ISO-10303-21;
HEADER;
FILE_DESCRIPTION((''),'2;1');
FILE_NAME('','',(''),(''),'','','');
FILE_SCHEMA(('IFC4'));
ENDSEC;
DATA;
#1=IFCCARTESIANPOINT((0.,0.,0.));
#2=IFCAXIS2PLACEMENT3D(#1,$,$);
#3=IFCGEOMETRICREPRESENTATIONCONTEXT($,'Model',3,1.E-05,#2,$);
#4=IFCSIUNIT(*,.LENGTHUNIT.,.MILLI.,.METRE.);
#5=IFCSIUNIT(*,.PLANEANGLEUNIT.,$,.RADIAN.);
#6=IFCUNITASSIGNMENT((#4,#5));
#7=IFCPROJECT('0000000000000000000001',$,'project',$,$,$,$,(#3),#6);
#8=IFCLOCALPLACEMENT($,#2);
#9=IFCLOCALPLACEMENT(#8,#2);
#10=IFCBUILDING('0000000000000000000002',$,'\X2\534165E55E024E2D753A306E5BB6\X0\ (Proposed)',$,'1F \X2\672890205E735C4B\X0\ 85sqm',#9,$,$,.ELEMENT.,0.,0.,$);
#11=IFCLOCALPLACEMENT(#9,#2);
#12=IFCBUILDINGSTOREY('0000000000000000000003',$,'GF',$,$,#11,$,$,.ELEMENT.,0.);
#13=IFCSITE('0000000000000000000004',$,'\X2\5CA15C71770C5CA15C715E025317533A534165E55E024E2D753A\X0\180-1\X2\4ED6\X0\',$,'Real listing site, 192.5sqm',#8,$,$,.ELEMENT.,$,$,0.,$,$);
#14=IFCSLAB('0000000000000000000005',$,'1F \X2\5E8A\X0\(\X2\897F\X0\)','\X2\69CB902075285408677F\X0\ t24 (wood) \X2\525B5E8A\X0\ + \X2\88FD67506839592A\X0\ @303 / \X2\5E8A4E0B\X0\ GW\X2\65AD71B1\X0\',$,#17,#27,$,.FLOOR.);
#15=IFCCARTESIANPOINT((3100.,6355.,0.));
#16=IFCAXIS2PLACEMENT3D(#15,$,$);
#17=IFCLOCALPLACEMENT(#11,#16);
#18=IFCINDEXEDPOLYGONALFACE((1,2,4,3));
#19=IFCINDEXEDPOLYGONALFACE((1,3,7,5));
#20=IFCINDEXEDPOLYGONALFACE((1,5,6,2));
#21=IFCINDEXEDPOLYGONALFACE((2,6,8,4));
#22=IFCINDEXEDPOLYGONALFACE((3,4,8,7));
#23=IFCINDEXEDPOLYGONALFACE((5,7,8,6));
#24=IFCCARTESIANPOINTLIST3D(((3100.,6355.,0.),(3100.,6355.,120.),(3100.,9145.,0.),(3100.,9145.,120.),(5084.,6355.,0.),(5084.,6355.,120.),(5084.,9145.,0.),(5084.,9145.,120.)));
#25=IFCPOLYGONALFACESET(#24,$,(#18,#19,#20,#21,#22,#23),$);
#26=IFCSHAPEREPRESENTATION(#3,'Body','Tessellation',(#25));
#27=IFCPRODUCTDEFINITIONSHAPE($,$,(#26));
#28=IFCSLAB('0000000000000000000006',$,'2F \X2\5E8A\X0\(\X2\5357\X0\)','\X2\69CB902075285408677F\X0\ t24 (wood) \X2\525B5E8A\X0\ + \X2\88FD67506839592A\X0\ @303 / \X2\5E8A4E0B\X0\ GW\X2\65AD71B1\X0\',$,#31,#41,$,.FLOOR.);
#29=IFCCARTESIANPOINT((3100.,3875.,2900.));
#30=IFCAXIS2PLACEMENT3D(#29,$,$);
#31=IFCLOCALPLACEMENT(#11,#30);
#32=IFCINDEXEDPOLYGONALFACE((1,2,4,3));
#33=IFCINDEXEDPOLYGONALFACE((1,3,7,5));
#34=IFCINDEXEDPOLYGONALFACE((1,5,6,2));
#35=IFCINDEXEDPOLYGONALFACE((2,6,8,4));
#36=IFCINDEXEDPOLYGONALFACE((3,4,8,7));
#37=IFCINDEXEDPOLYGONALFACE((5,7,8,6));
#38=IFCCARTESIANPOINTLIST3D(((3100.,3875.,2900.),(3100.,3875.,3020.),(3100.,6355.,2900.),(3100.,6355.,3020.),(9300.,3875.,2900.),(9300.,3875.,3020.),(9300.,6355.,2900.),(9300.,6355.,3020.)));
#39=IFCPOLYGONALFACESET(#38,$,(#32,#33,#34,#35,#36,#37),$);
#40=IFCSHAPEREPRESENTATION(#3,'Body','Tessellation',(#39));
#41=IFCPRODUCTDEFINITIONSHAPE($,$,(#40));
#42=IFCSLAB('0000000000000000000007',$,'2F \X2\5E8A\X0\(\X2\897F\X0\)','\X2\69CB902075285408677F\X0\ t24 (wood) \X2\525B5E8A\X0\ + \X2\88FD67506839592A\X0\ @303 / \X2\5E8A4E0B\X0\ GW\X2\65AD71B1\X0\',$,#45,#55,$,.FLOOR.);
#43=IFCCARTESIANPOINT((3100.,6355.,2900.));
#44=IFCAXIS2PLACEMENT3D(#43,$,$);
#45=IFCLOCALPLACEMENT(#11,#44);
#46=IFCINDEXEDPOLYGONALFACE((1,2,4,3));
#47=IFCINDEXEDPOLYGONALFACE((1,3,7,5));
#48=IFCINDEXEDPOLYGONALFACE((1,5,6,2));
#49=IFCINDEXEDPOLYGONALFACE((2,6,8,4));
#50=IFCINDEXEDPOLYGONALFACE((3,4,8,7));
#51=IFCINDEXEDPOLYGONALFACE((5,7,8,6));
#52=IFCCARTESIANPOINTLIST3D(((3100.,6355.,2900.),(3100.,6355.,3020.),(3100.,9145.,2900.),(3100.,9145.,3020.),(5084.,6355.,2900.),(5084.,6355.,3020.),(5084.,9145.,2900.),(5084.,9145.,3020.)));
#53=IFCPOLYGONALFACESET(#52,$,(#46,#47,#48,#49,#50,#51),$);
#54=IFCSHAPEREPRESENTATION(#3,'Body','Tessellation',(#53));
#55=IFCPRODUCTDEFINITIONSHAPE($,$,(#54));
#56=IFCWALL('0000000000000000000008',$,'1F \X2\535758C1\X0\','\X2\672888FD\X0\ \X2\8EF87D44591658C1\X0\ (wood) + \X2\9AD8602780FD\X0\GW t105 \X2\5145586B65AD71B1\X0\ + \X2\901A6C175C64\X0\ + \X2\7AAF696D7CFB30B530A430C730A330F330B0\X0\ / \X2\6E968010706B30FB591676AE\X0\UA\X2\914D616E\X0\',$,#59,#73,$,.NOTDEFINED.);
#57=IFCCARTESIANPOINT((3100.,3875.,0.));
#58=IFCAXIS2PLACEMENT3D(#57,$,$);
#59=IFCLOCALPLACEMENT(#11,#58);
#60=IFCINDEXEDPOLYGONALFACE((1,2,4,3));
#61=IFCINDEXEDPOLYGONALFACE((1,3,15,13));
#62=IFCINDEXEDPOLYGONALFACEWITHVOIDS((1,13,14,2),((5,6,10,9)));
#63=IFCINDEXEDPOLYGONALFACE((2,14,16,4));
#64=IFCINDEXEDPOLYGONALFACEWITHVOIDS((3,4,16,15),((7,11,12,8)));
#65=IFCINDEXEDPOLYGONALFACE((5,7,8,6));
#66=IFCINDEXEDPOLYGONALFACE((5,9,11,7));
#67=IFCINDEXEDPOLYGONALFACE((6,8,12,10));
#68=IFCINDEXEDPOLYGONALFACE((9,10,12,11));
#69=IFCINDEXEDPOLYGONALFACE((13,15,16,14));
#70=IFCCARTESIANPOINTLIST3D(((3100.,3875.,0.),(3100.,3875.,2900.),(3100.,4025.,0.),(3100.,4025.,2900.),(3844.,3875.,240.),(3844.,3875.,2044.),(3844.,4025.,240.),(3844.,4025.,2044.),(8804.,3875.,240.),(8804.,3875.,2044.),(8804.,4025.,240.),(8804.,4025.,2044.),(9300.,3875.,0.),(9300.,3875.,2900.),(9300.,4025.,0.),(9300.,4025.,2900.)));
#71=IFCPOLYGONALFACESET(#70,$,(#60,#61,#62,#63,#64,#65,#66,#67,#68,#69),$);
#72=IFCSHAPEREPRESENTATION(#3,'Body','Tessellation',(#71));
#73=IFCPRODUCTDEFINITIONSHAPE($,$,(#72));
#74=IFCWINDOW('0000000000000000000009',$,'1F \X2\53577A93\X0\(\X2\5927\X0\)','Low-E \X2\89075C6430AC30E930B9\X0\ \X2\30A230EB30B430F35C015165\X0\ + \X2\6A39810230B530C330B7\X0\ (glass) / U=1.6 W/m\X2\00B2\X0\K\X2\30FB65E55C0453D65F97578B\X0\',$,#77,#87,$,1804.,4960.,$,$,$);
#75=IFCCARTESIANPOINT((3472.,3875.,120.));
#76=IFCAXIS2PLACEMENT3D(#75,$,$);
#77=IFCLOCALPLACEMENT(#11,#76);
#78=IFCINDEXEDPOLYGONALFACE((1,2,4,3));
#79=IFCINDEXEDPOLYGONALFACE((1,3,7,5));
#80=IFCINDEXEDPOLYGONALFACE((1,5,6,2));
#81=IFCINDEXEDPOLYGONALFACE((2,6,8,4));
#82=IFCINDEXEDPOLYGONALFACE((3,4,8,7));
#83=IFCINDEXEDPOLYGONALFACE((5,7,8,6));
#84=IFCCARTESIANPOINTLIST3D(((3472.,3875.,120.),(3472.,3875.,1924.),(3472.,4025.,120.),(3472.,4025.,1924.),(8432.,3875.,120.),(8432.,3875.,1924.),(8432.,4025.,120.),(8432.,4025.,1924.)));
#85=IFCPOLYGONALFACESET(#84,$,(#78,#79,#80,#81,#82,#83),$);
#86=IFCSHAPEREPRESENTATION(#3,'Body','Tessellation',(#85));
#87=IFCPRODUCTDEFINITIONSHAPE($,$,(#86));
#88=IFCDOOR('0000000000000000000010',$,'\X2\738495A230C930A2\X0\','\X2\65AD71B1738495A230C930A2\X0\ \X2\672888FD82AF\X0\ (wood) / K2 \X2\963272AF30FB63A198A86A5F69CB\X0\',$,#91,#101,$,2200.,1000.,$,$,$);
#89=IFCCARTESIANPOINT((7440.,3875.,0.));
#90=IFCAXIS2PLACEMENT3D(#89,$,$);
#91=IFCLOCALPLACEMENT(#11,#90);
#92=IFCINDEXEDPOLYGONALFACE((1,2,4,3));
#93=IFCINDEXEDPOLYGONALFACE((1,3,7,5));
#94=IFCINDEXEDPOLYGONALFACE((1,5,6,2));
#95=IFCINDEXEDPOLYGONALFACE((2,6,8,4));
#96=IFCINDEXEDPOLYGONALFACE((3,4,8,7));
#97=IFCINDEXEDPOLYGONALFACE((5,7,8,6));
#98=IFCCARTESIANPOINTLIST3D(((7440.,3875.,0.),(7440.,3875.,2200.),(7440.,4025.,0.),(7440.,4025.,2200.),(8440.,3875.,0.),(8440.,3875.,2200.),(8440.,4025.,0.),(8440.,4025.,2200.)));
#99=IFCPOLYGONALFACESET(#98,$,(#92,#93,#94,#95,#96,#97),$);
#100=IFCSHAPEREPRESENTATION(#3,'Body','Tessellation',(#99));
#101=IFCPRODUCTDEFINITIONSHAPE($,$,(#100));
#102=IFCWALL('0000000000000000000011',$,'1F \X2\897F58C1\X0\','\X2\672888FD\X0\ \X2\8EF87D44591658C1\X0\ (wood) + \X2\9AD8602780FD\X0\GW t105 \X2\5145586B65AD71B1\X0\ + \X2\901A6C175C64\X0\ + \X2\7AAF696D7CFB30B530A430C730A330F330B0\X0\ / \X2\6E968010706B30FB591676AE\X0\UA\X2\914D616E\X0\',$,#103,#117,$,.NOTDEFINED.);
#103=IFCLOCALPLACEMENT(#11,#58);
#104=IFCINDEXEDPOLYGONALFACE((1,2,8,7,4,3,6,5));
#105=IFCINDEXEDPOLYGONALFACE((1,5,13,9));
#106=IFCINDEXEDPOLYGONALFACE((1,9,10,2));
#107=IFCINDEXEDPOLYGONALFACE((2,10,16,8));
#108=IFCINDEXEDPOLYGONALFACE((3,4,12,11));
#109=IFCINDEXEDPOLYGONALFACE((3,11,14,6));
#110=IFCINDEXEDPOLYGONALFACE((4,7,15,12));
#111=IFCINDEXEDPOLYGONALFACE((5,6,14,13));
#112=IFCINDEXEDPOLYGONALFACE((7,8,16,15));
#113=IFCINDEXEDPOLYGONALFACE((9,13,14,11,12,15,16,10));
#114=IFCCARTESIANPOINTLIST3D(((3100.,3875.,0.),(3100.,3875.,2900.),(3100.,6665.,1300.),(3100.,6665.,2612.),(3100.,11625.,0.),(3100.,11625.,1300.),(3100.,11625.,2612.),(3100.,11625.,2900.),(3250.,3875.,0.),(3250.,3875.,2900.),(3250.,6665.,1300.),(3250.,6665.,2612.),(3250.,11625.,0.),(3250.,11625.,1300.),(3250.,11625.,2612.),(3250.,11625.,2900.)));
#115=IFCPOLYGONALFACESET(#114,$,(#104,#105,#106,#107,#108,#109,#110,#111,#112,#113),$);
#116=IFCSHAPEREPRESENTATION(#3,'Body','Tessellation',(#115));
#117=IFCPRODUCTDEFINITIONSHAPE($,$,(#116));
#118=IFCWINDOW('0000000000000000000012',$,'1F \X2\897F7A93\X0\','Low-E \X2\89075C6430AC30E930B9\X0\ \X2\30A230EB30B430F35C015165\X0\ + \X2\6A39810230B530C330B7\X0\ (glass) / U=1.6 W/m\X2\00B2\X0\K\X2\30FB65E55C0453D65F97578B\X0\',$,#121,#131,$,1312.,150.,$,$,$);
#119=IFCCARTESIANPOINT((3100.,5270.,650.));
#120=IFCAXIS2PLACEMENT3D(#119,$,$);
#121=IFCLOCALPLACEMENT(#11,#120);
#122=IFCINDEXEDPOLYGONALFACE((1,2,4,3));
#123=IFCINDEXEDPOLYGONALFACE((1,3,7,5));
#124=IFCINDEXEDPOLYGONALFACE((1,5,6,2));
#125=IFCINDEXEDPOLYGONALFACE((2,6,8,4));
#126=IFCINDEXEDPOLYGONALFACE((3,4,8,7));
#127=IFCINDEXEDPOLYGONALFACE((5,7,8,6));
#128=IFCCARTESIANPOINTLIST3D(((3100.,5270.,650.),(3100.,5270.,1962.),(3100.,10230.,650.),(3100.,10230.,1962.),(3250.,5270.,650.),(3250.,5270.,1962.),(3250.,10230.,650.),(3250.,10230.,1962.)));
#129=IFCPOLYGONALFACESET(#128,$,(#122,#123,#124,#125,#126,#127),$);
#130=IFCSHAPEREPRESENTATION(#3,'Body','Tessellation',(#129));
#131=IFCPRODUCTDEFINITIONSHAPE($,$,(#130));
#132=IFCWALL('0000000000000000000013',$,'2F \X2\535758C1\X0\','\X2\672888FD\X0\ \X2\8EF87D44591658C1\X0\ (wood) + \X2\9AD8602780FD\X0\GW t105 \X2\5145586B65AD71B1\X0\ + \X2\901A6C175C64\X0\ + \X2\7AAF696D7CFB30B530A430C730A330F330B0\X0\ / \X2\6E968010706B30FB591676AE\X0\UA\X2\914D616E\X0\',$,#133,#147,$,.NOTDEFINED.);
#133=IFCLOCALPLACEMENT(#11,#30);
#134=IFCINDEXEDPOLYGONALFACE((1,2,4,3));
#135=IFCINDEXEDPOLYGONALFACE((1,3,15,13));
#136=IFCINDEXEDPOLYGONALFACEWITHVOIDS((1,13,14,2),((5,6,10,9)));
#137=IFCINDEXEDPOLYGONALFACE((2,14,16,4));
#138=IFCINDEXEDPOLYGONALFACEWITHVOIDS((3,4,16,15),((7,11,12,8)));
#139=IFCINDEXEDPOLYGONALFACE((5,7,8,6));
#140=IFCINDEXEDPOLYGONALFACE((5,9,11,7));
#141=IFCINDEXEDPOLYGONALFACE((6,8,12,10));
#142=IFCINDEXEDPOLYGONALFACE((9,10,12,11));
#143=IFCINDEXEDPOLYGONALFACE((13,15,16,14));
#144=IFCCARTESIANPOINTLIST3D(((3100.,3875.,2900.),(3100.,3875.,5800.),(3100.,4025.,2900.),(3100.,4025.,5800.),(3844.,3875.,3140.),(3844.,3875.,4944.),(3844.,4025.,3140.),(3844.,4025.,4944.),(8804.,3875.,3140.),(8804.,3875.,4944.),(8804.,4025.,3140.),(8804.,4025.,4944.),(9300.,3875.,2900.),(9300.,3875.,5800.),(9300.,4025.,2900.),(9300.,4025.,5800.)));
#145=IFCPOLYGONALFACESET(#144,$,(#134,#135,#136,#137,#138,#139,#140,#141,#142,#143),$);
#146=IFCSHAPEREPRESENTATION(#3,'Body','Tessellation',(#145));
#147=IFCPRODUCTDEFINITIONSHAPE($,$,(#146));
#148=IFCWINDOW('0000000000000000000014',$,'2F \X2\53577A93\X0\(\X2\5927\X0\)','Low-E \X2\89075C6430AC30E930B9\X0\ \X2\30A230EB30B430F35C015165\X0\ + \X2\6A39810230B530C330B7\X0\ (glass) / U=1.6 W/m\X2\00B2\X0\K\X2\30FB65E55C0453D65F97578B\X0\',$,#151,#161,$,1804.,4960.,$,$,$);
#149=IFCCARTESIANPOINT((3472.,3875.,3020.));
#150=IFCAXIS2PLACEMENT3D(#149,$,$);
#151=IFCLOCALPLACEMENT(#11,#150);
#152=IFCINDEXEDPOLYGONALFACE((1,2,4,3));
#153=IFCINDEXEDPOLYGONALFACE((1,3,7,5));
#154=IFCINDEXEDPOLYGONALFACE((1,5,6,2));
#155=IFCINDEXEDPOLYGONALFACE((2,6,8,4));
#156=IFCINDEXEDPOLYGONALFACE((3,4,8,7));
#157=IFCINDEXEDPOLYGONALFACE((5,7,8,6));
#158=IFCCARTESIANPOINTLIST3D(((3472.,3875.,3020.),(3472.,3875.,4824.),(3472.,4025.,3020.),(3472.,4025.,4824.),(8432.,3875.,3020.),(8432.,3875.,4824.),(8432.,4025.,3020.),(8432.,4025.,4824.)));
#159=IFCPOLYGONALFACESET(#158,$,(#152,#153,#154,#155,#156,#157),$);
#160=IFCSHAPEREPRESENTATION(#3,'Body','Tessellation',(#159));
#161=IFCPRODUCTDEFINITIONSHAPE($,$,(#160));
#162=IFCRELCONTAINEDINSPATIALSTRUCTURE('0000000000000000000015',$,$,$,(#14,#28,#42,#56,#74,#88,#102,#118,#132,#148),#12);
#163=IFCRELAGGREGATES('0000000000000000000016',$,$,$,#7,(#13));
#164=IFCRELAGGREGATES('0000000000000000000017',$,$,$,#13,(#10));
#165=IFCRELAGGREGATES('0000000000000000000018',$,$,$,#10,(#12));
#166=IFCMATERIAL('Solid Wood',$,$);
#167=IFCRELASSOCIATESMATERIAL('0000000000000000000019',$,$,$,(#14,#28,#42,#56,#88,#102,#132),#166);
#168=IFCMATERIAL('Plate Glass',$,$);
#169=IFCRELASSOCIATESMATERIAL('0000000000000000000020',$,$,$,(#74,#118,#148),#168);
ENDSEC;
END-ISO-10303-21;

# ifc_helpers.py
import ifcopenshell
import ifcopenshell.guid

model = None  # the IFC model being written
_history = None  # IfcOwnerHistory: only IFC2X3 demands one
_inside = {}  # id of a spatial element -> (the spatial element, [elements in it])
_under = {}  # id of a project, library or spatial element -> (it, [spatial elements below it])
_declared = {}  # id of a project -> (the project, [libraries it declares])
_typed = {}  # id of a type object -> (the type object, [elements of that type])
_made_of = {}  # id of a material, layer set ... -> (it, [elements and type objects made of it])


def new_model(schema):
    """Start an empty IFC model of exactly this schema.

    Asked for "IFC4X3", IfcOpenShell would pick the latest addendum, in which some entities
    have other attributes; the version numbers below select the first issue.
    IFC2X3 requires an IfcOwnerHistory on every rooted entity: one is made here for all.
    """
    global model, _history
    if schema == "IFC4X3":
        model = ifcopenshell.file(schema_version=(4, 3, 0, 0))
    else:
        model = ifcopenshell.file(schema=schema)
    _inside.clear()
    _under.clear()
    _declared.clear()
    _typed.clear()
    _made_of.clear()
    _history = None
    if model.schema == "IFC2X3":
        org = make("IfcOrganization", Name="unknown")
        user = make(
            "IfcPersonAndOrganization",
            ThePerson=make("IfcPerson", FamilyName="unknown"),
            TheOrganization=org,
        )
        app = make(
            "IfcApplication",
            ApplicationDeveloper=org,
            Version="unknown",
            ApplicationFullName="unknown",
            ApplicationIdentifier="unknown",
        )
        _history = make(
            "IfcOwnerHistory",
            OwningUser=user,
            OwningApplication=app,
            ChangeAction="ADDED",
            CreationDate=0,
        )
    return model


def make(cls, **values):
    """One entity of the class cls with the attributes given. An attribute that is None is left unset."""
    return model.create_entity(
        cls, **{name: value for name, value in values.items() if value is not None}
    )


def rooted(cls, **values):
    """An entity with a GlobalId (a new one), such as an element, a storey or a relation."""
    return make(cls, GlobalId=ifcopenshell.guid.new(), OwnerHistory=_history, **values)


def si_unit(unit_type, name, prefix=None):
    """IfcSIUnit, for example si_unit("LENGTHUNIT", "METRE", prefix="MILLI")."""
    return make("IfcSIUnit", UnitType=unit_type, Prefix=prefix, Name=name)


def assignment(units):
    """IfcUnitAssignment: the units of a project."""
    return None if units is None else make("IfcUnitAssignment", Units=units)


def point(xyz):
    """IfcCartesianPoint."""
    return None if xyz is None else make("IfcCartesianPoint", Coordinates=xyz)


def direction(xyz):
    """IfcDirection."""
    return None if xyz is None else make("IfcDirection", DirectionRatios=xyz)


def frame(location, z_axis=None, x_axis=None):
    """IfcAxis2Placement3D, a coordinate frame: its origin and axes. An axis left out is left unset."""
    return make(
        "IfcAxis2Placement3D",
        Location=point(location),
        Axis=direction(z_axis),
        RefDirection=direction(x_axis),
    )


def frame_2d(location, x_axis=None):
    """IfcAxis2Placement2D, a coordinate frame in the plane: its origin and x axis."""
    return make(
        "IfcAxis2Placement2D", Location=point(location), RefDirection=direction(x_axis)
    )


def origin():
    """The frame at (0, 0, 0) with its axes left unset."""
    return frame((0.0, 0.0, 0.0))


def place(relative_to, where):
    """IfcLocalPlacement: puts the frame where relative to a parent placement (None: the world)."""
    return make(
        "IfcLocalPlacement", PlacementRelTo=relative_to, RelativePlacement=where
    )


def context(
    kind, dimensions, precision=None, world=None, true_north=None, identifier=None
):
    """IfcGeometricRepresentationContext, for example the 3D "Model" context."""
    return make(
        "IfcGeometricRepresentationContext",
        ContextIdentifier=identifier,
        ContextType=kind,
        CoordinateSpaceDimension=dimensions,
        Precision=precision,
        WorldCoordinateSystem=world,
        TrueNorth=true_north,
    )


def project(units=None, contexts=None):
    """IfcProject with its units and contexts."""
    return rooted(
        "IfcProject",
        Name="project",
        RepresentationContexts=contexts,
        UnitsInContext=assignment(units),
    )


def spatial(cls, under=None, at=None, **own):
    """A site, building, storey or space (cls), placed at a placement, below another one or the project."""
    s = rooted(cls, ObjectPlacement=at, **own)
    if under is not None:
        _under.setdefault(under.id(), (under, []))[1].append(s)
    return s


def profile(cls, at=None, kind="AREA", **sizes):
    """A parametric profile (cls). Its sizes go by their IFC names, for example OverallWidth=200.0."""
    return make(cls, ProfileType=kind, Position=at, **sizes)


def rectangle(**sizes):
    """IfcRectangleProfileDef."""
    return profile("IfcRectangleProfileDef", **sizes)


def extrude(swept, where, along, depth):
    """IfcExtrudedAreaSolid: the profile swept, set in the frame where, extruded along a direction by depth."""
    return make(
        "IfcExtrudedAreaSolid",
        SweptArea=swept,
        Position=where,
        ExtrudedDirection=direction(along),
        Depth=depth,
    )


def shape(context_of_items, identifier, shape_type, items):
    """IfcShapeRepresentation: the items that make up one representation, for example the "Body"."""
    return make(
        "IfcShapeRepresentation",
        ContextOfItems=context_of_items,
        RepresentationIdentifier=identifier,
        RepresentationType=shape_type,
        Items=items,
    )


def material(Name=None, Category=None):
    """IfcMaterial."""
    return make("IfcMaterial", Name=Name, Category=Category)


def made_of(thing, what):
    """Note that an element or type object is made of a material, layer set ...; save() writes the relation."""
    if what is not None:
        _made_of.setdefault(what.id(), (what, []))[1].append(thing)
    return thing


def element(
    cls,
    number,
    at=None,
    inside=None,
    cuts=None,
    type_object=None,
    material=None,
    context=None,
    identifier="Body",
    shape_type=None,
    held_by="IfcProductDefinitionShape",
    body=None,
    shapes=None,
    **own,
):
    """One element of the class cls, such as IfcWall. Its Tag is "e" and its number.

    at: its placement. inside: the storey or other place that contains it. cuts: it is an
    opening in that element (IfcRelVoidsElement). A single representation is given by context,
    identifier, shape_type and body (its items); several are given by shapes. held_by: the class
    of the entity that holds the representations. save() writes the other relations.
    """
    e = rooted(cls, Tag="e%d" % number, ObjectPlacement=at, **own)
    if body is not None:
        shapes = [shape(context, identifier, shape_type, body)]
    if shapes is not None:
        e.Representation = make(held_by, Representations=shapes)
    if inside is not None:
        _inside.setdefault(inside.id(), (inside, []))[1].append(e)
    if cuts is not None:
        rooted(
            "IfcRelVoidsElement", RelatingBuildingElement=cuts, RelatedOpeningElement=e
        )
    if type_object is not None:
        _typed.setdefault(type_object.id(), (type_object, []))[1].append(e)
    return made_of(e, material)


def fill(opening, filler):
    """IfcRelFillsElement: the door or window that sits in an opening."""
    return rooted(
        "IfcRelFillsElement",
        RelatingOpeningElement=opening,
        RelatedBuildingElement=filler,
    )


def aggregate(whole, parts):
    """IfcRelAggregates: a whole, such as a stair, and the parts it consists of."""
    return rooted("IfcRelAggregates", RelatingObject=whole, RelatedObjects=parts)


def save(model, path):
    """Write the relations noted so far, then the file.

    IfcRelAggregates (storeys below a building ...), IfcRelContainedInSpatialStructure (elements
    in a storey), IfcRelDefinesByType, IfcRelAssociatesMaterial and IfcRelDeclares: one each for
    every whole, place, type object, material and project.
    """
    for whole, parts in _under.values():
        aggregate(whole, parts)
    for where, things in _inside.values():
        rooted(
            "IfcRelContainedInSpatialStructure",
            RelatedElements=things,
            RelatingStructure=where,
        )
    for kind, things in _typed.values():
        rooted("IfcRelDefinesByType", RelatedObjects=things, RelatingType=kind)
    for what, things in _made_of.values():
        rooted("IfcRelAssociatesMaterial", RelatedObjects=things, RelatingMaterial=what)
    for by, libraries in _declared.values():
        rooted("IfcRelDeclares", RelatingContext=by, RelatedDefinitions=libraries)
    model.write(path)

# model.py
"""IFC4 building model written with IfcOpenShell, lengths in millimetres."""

from ifc_helpers import new_model, si_unit, frame, frame_2d, origin, place, context, project, spatial, rectangle, extrude, material, element, fill, save


model = new_model("IFC4")

# Units and contexts
model_context = context("Model", 3, precision=1e-05, world=origin())
ifc_project = project(units=[si_unit("LENGTHUNIT", "METRE", prefix="MILLI"), si_unit("PLANEANGLEUNIT", "RADIAN")], contexts=[model_context])

# Site, building, storey
site_placement = place(None, origin())
site = spatial("IfcSite", under=ifc_project, at=site_placement, Name="岡山県岡山市北区十日市中町180-1他", ObjectType="Real listing site, 192.5sqm", CompositionType="ELEMENT", RefElevation=0.0)
building_placement = place(site_placement, origin())
building = spatial("IfcBuilding", under=site, at=building_placement, Name="十日市中町の家 (Proposed)", ObjectType="1F 木造平屋 85sqm", CompositionType="ELEMENT", ElevationOfRefHeight=0.0, ElevationOfTerrain=0.0)
storey_placement = place(building_placement, origin())
storey = spatial("IfcBuildingStorey", under=building, at=storey_placement, Name="GF", CompositionType="ELEMENT", Elevation=0.0)

# Slabs
ifc_material_1 = material(Name="Solid Wood")
slab_1_placement = place(storey_placement, frame((3100.0, 6355.0, 0.0)))
element("IfcSlab", 1, at=slab_1_placement, inside=storey, material=ifc_material_1, Name="1F 床(西)", Description="構造用合板 t24 (wood) 剛床 + 製材根太 @303 / 床下 GW断熱", PredefinedType="FLOOR", context=model_context, shape_type="SweptSolid", body=[
    extrude(rectangle(XDim=1984.0, YDim=2790.0, at=frame_2d((992.0, 1395.0))), frame((3100.0, 6355.0, 0.0)), (0.0, 0.0, 1.0), 120.0),
])
slab_2_placement = place(storey_placement, frame((3100.0, 3875.0, 2900.0)))
element("IfcSlab", 2, at=slab_2_placement, inside=storey, material=ifc_material_1, Name="2F 床(南)", Description="構造用合板 t24 (wood) 剛床 + 製材根太 @303 / 床下 GW断熱", PredefinedType="FLOOR", context=model_context, shape_type="SweptSolid", body=[
    extrude(rectangle(XDim=6200.0, YDim=2480.0, at=frame_2d((3100.0, 1240.0))), frame((3100.0, 3875.0, 2900.0)), (0.0, 0.0, 1.0), 120.0),
])
slab_3_placement = place(storey_placement, frame((3100.0, 6355.0, 2900.0)))
element("IfcSlab", 3, at=slab_3_placement, inside=storey, material=ifc_material_1, Name="2F 床(西)", Description="構造用合板 t24 (wood) 剛床 + 製材根太 @303 / 床下 GW断熱", PredefinedType="FLOOR", context=model_context, shape_type="SweptSolid", body=[
    extrude(rectangle(XDim=1984.0, YDim=2790.0, at=frame_2d((992.0, 1395.0))), frame((3100.0, 6355.0, 2900.0)), (0.0, 0.0, 1.0), 120.0),
])

# Wall, openings, window, door
wall_1_placement = place(storey_placement, frame((3100.0, 3875.0, 0.0)))
wall_1 = element("IfcWall", 4, at=wall_1_placement, inside=storey, material=ifc_material_1, Name="1F 南壁", Description="木製 軸組外壁 (wood) + 高性能GW t105 充填断熱 + 通気層 + 窯業系サイディング / 準耐火・外皮UA配慮", PredefinedType="NOTDEFINED", context=model_context, shape_type="SweptSolid", body=[
    extrude(rectangle(XDim=6200.0, YDim=150.0, at=frame_2d((3100.0, 75.0))), frame((3100.0, 3875.0, 0.0)), (0.0, 0.0, 1.0), 2900.0),
])
opening_1_placement = place(storey_placement, frame((3472.0, 3875.0, 120.0)))
opening_1 = element("IfcOpeningElement", 5, at=opening_1_placement, cuts=wall_1, PredefinedType="NOTDEFINED", context=model_context, shape_type="SweptSolid", body=[
    extrude(rectangle(XDim=4960.0, YDim=150.0, at=frame_2d((2480.0, 75.0))), frame((3472.0, 3875.0, 120.0)), (0.0, 0.0, 1.0), 1804.0),
])
opening_2_placement = place(storey_placement, frame((7440.0, 3875.0, 0.0)))
opening_2 = element("IfcOpeningElement", 6, at=opening_2_placement, cuts=wall_1, PredefinedType="NOTDEFINED", context=model_context, shape_type="SweptSolid", body=[
    extrude(rectangle(XDim=1000.0, YDim=150.0, at=frame_2d((500.0, 75.0))), frame((7440.0, 3875.0, 0.0)), (0.0, 0.0, 1.0), 2200.0),
])
ifc_material_2 = material(Name="Plate Glass")
window_1_placement = place(storey_placement, frame((3472.0, 3875.0, 120.0)))
window_1 = element("IfcWindow", 7, at=window_1_placement, inside=storey, material=ifc_material_2, Name="1F 南窓(大)", Description="Low-E 複層ガラス アルゴン封入 + 樹脂サッシ (glass) / U=1.6 W/m²K・日射取得型", OverallHeight=1804.0, OverallWidth=4960.0, context=model_context, shape_type="SweptSolid", body=[
    extrude(rectangle(XDim=4960.0, YDim=150.0, at=frame_2d((2480.0, 75.0))), frame((3472.0, 3875.0, 120.0)), (0.0, 0.0, 1.0), 1804.0),
])
fill(opening_1, window_1)
door_placement = place(storey_placement, frame((7440.0, 3875.0, 0.0)))
door = element("IfcDoor", 8, at=door_placement, inside=storey, material=ifc_material_1, Name="玄関ドア", Description="断熱玄関ドア 木製芯 (wood) / K2 防犯・採風機構", OverallHeight=2200.0, OverallWidth=1000.0, context=model_context, shape_type="SweptSolid", body=[
    extrude(rectangle(XDim=1000.0, YDim=150.0, at=frame_2d((500.0, 75.0))), frame((7440.0, 3875.0, 0.0)), (0.0, 0.0, 1.0), 2200.0),
])
fill(opening_2, door)

# Walls, openings, windows
wall_2_placement = place(storey_placement, frame((3100.0, 3875.0, 0.0)))
wall_2 = element("IfcWall", 9, at=wall_2_placement, inside=storey, material=ifc_material_1, Name="1F 西壁", Description="木製 軸組外壁 (wood) + 高性能GW t105 充填断熱 + 通気層 + 窯業系サイディング / 準耐火・外皮UA配慮", PredefinedType="NOTDEFINED", context=model_context, shape_type="SweptSolid", body=[
    extrude(rectangle(XDim=150.0, YDim=7750.0, at=frame_2d((75.0, 3875.0))), frame((3100.0, 3875.0, 0.0)), (0.0, 0.0, 1.0), 2900.0),
])
opening_3_placement = place(storey_placement, frame((3100.0, 5270.0, 650.0)))
opening_3 = element("IfcOpeningElement", 10, at=opening_3_placement, cuts=wall_2, PredefinedType="NOTDEFINED", context=model_context, shape_type="SweptSolid", body=[
    extrude(rectangle(XDim=150.0, YDim=4960.0, at=frame_2d((75.0, 2480.0))), frame((3100.0, 5270.0, 650.0)), (0.0, 0.0, 1.0), 1312.0),
])
window_2_placement = place(storey_placement, frame((3100.0, 5270.0, 650.0)))
window_2 = element("IfcWindow", 11, at=window_2_placement, inside=storey, material=ifc_material_2, Name="1F 西窓", Description="Low-E 複層ガラス アルゴン封入 + 樹脂サッシ (glass) / U=1.6 W/m²K・日射取得型", OverallHeight=1312.0, OverallWidth=150.0, context=model_context, shape_type="SweptSolid", body=[
    extrude(rectangle(XDim=150.0, YDim=4960.0, at=frame_2d((75.0, 2480.0))), frame((3100.0, 5270.0, 650.0)), (0.0, 0.0, 1.0), 1312.0),
])
fill(opening_3, window_2)
wall_3_placement = place(storey_placement, frame((3100.0, 3875.0, 2900.0)))
wall_3 = element("IfcWall", 12, at=wall_3_placement, inside=storey, material=ifc_material_1, Name="2F 南壁", Description="木製 軸組外壁 (wood) + 高性能GW t105 充填断熱 + 通気層 + 窯業系サイディング / 準耐火・外皮UA配慮", PredefinedType="NOTDEFINED", context=model_context, shape_type="SweptSolid", body=[
    extrude(rectangle(XDim=6200.0, YDim=150.0, at=frame_2d((3100.0, 75.0))), frame((3100.0, 3875.0, 2900.0)), (0.0, 0.0, 1.0), 2900.0),
])
opening_4_placement = place(storey_placement, frame((3472.0, 3875.0, 3020.0)))
opening_4 = element("IfcOpeningElement", 13, at=opening_4_placement, cuts=wall_3, PredefinedType="NOTDEFINED", context=model_context, shape_type="SweptSolid", body=[
    extrude(rectangle(XDim=4960.0, YDim=150.0, at=frame_2d((2480.0, 75.0))), frame((3472.0, 3875.0, 3020.0)), (0.0, 0.0, 1.0), 1804.0),
])
window_3_placement = place(storey_placement, frame((3472.0, 3875.0, 3020.0)))
window_3 = element("IfcWindow", 14, at=window_3_placement, inside=storey, material=ifc_material_2, Name="2F 南窓(大)", Description="Low-E 複層ガラス アルゴン封入 + 樹脂サッシ (glass) / U=1.6 W/m²K・日射取得型", OverallHeight=1804.0, OverallWidth=4960.0, context=model_context, shape_type="SweptSolid", body=[
    extrude(rectangle(XDim=4960.0, YDim=150.0, at=frame_2d((2480.0, 75.0))), frame((3472.0, 3875.0, 3020.0)), (0.0, 0.0, 1.0), 1804.0),
])
fill(opening_4, window_3)

save(model, "model.ifc")
